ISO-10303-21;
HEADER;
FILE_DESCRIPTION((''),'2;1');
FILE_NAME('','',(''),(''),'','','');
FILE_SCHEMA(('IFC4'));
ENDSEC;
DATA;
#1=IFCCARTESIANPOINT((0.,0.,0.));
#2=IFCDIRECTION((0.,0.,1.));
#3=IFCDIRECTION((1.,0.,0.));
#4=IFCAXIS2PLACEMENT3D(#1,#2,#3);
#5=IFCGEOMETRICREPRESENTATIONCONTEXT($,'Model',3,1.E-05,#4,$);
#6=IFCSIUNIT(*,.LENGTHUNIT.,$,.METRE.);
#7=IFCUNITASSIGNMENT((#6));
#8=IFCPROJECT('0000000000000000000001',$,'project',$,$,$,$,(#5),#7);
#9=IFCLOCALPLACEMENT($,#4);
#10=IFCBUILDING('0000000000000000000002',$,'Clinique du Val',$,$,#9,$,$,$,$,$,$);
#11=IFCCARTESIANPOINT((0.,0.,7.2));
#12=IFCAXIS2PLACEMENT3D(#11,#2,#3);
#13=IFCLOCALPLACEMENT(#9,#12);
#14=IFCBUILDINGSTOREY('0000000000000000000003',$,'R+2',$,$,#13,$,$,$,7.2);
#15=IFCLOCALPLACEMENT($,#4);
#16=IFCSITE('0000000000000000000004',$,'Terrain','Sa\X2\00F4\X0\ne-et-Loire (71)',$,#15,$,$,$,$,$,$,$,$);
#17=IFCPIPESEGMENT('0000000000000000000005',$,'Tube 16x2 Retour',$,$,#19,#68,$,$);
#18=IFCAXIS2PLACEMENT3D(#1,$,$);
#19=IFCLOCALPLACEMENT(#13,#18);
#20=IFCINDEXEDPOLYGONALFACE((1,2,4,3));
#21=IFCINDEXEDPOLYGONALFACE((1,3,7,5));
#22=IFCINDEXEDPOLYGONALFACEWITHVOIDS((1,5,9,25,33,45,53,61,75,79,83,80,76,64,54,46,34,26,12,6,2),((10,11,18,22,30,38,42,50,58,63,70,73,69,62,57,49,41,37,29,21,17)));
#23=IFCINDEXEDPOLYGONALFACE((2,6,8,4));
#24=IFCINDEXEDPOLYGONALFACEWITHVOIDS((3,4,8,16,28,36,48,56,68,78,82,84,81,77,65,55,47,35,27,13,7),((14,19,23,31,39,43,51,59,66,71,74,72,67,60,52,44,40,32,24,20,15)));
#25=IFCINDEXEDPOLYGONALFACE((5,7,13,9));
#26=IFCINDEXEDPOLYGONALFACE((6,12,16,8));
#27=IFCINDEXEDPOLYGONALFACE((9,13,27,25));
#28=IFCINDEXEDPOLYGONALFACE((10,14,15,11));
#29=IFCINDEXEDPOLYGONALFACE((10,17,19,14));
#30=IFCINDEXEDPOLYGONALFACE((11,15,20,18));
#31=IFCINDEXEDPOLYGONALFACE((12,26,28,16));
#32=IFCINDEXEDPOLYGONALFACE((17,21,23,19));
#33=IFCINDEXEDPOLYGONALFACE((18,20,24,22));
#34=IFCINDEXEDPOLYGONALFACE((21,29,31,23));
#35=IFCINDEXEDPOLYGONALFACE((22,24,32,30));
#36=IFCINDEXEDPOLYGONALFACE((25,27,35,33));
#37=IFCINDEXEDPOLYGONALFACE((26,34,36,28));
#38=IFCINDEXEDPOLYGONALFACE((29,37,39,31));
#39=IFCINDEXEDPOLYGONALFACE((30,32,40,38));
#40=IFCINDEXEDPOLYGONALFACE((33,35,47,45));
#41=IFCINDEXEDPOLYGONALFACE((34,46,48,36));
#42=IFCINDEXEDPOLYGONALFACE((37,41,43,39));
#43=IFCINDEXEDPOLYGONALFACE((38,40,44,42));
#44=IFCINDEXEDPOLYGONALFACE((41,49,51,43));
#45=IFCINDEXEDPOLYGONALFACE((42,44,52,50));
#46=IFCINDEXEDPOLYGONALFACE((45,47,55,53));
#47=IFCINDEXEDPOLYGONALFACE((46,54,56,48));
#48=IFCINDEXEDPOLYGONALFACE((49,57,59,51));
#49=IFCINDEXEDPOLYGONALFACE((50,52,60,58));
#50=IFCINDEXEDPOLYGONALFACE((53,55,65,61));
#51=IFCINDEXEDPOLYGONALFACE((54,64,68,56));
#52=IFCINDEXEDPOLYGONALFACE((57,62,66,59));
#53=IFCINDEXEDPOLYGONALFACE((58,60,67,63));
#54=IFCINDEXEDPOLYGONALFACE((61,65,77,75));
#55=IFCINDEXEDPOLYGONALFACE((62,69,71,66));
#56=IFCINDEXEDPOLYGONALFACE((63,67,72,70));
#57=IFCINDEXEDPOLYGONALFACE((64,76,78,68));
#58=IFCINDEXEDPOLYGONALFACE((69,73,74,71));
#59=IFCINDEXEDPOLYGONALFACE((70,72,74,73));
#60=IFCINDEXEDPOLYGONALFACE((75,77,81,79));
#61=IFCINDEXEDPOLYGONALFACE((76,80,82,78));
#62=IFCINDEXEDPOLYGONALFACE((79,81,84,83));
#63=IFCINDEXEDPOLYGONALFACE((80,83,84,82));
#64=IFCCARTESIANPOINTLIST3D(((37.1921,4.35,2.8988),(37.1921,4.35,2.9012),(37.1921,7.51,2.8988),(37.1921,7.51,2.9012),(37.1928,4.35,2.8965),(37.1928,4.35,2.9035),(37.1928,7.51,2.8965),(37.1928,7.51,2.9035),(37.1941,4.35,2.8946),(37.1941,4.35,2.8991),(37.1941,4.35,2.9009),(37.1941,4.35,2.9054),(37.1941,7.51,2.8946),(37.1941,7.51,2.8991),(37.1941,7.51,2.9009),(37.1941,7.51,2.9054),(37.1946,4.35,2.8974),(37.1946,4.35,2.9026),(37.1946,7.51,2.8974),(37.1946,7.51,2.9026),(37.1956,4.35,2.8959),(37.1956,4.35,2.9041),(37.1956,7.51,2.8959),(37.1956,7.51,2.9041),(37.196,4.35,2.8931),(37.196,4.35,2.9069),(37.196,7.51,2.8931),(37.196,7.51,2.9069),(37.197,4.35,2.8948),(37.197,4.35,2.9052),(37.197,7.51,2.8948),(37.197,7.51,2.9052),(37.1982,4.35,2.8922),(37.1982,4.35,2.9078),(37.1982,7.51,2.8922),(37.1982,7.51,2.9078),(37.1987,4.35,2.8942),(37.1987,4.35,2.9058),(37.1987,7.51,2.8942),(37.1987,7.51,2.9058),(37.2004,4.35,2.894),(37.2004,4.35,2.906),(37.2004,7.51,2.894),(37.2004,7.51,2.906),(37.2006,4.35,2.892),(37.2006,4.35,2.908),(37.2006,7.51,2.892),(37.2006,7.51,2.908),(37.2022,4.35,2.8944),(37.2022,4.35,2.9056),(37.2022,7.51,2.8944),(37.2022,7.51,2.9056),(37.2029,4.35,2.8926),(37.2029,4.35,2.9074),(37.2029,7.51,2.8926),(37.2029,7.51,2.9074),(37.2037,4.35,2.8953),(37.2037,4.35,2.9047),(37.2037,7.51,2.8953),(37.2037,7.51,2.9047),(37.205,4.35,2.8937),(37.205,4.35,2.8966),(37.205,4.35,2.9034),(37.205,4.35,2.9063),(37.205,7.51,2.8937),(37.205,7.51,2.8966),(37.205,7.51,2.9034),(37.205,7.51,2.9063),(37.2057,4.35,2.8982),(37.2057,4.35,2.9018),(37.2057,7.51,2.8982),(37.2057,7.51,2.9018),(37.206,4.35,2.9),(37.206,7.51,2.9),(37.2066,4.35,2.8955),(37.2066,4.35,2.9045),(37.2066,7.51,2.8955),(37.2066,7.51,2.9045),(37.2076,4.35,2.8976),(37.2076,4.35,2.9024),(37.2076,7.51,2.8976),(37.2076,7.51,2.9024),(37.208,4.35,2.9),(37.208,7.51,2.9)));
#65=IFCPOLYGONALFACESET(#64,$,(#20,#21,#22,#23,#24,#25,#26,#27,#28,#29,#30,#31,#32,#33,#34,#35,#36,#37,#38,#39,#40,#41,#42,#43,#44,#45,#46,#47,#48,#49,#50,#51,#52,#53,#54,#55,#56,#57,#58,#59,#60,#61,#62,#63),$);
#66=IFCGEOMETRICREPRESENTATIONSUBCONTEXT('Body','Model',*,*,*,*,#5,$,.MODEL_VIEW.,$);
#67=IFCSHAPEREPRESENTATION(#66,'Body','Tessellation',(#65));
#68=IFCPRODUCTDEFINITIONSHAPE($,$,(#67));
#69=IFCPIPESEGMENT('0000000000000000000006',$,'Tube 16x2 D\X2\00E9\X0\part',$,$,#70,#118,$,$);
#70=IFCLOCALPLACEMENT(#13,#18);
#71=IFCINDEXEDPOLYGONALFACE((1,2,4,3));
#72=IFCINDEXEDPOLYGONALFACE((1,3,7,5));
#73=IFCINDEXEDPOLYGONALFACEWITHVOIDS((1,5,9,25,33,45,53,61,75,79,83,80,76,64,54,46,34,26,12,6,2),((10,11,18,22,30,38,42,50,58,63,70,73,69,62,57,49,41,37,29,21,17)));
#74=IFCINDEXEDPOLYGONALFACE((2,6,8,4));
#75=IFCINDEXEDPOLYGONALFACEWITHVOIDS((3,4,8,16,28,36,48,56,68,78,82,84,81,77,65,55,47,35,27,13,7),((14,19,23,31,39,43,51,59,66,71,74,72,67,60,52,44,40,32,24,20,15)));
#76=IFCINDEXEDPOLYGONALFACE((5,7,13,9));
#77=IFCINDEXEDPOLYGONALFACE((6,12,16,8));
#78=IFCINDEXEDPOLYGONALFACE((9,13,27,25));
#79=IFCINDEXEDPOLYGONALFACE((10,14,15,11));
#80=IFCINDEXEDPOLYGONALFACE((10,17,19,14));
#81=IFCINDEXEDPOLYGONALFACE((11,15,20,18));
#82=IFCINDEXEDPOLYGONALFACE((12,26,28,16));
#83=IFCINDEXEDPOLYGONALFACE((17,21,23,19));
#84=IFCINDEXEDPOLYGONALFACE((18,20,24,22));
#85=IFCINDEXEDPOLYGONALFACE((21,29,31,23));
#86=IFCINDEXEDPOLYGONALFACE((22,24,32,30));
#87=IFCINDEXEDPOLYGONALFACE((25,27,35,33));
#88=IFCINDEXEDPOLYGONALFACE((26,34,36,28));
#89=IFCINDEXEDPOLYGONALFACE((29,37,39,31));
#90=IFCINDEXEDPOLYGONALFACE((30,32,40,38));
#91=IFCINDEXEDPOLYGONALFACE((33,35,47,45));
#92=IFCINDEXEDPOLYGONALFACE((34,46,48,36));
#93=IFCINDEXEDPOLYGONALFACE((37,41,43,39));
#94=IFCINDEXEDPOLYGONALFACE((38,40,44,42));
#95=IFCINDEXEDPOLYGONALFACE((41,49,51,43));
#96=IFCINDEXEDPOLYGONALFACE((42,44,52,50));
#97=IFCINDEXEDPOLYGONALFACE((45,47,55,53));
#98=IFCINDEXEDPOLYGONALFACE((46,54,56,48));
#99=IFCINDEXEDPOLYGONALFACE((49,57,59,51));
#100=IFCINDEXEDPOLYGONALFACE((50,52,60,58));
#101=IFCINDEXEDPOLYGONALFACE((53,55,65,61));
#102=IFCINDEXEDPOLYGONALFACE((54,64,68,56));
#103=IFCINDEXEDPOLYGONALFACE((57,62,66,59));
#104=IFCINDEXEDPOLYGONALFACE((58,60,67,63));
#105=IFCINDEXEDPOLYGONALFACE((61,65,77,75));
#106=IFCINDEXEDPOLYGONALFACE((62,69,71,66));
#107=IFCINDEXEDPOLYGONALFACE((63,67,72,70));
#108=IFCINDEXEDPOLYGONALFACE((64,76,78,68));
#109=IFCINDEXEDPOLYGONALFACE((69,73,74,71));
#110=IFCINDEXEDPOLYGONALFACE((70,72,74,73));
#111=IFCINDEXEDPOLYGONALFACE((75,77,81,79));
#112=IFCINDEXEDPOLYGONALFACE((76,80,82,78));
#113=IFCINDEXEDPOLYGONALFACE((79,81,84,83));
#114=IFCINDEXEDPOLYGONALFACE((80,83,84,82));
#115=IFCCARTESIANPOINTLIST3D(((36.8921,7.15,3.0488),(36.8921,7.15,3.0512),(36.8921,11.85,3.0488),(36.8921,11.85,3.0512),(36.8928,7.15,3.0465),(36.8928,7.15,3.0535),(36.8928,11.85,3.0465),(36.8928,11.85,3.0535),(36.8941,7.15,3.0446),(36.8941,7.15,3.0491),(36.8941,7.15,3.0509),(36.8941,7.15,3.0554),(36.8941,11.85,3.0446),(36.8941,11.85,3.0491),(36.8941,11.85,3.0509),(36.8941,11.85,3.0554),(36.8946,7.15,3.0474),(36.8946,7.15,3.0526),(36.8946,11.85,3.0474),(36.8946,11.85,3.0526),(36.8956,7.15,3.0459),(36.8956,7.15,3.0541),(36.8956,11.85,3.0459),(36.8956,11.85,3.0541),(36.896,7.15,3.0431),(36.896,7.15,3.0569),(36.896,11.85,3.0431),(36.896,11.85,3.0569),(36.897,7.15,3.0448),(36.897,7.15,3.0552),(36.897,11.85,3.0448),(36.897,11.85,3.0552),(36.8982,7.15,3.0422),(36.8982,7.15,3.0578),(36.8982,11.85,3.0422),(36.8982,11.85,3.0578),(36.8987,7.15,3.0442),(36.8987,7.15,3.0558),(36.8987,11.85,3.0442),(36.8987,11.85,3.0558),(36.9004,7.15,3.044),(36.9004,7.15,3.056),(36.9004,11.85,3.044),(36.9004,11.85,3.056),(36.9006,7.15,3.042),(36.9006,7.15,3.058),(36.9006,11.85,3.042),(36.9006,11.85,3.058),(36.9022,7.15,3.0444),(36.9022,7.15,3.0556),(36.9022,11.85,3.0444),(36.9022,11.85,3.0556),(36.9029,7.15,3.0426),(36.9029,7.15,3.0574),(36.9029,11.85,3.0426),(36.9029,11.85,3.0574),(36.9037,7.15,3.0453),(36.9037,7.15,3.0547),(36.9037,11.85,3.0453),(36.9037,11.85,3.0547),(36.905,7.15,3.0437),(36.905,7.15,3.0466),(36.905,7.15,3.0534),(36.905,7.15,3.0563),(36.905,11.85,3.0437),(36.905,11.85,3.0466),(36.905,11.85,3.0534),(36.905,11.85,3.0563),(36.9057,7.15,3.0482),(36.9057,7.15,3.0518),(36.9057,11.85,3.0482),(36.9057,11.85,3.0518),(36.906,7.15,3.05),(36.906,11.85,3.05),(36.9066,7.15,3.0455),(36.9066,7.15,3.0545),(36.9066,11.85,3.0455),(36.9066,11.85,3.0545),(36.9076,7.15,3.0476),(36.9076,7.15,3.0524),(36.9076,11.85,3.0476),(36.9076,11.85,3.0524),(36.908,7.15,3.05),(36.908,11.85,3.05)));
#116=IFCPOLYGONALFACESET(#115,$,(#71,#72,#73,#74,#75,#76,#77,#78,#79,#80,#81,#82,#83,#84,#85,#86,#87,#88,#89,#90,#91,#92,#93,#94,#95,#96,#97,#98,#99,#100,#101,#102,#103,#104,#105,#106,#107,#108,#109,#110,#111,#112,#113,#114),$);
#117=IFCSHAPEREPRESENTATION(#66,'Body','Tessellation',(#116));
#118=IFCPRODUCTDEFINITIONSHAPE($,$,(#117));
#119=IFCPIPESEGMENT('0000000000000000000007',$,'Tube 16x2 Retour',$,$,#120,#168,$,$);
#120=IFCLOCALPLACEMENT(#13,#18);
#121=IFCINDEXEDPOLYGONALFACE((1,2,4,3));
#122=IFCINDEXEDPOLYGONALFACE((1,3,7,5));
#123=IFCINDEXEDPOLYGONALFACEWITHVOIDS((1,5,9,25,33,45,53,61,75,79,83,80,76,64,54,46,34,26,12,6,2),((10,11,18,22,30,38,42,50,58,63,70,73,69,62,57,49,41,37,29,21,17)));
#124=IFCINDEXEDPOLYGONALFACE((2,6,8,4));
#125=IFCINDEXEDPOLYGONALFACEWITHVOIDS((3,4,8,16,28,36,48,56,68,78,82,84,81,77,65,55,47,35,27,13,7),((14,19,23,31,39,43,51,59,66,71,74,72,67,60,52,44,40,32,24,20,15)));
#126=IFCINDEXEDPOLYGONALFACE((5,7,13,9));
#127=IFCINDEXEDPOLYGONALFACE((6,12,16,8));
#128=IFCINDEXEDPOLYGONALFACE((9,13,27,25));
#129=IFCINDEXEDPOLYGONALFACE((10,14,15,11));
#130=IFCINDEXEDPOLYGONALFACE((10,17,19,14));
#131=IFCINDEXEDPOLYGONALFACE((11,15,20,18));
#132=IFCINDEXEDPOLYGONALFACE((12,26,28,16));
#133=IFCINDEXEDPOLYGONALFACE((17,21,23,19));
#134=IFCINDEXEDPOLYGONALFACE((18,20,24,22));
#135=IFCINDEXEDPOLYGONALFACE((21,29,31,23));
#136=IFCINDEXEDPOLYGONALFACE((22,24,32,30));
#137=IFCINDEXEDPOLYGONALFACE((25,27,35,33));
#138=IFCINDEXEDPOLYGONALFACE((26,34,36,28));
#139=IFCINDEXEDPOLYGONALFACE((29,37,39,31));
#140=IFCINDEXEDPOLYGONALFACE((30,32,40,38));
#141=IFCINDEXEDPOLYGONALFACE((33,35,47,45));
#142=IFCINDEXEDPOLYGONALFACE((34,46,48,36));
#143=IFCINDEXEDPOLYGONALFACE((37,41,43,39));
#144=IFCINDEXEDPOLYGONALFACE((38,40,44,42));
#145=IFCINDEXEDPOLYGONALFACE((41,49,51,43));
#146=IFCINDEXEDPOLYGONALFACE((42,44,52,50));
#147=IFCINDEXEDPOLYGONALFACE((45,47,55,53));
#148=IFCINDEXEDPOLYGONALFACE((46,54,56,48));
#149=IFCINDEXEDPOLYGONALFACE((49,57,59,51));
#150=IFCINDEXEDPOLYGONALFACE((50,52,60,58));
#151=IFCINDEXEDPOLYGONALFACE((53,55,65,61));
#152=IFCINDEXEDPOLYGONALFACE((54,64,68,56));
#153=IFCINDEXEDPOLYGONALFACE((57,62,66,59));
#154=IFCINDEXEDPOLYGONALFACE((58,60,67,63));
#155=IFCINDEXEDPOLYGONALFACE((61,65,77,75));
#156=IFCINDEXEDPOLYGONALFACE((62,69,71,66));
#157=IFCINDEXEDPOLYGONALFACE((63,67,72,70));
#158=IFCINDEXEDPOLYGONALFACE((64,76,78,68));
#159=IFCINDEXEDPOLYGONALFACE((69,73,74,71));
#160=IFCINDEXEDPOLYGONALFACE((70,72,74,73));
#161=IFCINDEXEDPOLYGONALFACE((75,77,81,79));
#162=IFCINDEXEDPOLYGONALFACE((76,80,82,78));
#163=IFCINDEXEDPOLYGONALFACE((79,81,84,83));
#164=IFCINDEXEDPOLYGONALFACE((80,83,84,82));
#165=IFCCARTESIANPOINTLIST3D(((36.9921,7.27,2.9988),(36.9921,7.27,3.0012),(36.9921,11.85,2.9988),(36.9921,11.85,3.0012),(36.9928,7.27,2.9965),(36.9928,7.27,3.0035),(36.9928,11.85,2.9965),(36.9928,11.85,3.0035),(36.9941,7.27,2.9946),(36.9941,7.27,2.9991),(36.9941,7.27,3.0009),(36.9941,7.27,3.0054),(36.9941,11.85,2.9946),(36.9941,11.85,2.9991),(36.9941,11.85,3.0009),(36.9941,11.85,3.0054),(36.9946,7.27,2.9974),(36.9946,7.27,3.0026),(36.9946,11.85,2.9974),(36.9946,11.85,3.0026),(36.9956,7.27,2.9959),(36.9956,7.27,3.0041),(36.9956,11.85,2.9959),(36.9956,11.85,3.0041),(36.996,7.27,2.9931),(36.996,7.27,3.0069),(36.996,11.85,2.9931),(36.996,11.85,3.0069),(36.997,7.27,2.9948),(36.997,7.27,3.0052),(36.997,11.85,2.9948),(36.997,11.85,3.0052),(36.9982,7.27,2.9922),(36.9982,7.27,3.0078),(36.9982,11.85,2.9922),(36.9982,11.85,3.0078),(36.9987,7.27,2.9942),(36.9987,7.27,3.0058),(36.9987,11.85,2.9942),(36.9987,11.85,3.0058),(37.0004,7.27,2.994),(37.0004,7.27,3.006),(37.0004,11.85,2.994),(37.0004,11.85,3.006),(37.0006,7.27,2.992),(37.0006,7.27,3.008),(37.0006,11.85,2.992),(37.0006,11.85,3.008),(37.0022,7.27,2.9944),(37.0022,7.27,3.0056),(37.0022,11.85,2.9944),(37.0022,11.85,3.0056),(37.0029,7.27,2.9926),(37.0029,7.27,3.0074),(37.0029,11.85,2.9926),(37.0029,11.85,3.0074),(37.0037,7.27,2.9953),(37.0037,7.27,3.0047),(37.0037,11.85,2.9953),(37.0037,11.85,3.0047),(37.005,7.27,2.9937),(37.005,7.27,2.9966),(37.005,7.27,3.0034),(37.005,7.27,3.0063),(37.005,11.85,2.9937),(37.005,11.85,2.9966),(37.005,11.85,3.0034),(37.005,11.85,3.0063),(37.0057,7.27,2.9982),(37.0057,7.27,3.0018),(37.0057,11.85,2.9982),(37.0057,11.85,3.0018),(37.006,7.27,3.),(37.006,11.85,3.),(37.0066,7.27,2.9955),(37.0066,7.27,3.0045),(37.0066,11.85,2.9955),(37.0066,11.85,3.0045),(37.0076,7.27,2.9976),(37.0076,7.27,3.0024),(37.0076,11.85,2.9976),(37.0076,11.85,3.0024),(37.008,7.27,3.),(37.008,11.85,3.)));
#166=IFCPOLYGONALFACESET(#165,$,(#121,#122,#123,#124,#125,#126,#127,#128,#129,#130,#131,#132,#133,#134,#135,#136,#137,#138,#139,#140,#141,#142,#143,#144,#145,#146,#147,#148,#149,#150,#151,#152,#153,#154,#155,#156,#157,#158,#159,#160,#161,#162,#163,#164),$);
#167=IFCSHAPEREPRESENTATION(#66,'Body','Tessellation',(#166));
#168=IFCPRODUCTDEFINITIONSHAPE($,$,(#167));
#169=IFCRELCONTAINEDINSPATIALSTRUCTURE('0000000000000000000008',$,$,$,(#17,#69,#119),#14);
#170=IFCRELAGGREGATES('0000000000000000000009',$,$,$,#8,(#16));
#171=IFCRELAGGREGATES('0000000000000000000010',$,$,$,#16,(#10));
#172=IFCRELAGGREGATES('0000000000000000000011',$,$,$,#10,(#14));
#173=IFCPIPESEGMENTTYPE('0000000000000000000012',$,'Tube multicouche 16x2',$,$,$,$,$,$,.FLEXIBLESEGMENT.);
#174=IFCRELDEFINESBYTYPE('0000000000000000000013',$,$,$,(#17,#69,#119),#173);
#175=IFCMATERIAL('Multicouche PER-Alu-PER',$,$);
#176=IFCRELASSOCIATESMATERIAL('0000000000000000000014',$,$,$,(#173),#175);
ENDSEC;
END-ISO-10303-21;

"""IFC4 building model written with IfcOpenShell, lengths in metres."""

from ifc_helpers import new_model, si_unit, frame, origin_with_axes, place, context, subcontext, project, spatial, hollow_circle, extrude, material, type_object, element, save


model = new_model("IFC4")

# Units and contexts
model_context = context("Model", 3, precision=1e-05, world=origin_with_axes())
body_context = subcontext(model_context, "Body", "Model", "MODEL_VIEW")
ifc_project = project(units=[si_unit("LENGTHUNIT", "METRE")], contexts=[model_context])

# Site, building, storey
site_placement = place(None, origin_with_axes())
site = spatial("IfcSite", under=ifc_project, at=site_placement, Name="Terrain", Description="Saône-et-Loire (71)")
building_placement = place(None, origin_with_axes())
building = spatial("IfcBuilding", under=site, at=building_placement, Name="Clinique du Val")
storey_placement = place(building_placement, frame((0.0, 0.0, 7.2), z_axis=(0.0, 0.0, 1.0), x_axis=(1.0, 0.0, 0.0)))
storey = spatial("IfcBuildingStorey", under=building, at=storey_placement, Name="R+2", Elevation=7.2)

# Pipe segments
ifc_material_1 = material(Name="Multicouche PER-Alu-PER")
pipe_segment_type_1 = type_object("IfcPipeSegmentType", Name="Tube multicouche 16x2", PredefinedType="FLEXIBLESEGMENT", material=ifc_material_1)
pipe_segment_1_placement = place(storey_placement, frame((37.2, 7.51, 2.9), z_axis=(0.0, -1.0, 0.0), x_axis=(1.0, 0.0, 0.0)))
element("IfcPipeSegment", 1, at=pipe_segment_1_placement, inside=storey, type_object=pipe_segment_type_1, Name="Tube 16x2 Retour", context=body_context, shape_type="SweptSolid", body=[
    extrude(hollow_circle(Radius=0.008, WallThickness=0.002), origin_with_axes(), (0.0, 0.0, 1.0), 3.16),
])
pipe_segment_2_placement = place(storey_placement, frame((36.9, 7.15, 3.05), z_axis=(0.0, 1.0, 0.0), x_axis=(1.0, 0.0, 0.0)))
element("IfcPipeSegment", 2, at=pipe_segment_2_placement, inside=storey, type_object=pipe_segment_type_1, Name="Tube 16x2 Départ", context=body_context, shape_type="SweptSolid", body=[
    extrude(hollow_circle(Radius=0.008, WallThickness=0.002), origin_with_axes(), (0.0, 0.0, 1.0), 4.7),
])
pipe_segment_3_placement = place(storey_placement, frame((37.0, 7.27, 3.0), z_axis=(0.0, 1.0, 0.0), x_axis=(1.0, 0.0, 0.0)))
element("IfcPipeSegment", 3, at=pipe_segment_3_placement, inside=storey, type_object=pipe_segment_type_1, Name="Tube 16x2 Retour", context=body_context, shape_type="SweptSolid", body=[
    extrude(hollow_circle(Radius=0.008, WallThickness=0.002), origin_with_axes(), (0.0, 0.0, 1.0), 4.58),
])

save(model, "model.ifc")
